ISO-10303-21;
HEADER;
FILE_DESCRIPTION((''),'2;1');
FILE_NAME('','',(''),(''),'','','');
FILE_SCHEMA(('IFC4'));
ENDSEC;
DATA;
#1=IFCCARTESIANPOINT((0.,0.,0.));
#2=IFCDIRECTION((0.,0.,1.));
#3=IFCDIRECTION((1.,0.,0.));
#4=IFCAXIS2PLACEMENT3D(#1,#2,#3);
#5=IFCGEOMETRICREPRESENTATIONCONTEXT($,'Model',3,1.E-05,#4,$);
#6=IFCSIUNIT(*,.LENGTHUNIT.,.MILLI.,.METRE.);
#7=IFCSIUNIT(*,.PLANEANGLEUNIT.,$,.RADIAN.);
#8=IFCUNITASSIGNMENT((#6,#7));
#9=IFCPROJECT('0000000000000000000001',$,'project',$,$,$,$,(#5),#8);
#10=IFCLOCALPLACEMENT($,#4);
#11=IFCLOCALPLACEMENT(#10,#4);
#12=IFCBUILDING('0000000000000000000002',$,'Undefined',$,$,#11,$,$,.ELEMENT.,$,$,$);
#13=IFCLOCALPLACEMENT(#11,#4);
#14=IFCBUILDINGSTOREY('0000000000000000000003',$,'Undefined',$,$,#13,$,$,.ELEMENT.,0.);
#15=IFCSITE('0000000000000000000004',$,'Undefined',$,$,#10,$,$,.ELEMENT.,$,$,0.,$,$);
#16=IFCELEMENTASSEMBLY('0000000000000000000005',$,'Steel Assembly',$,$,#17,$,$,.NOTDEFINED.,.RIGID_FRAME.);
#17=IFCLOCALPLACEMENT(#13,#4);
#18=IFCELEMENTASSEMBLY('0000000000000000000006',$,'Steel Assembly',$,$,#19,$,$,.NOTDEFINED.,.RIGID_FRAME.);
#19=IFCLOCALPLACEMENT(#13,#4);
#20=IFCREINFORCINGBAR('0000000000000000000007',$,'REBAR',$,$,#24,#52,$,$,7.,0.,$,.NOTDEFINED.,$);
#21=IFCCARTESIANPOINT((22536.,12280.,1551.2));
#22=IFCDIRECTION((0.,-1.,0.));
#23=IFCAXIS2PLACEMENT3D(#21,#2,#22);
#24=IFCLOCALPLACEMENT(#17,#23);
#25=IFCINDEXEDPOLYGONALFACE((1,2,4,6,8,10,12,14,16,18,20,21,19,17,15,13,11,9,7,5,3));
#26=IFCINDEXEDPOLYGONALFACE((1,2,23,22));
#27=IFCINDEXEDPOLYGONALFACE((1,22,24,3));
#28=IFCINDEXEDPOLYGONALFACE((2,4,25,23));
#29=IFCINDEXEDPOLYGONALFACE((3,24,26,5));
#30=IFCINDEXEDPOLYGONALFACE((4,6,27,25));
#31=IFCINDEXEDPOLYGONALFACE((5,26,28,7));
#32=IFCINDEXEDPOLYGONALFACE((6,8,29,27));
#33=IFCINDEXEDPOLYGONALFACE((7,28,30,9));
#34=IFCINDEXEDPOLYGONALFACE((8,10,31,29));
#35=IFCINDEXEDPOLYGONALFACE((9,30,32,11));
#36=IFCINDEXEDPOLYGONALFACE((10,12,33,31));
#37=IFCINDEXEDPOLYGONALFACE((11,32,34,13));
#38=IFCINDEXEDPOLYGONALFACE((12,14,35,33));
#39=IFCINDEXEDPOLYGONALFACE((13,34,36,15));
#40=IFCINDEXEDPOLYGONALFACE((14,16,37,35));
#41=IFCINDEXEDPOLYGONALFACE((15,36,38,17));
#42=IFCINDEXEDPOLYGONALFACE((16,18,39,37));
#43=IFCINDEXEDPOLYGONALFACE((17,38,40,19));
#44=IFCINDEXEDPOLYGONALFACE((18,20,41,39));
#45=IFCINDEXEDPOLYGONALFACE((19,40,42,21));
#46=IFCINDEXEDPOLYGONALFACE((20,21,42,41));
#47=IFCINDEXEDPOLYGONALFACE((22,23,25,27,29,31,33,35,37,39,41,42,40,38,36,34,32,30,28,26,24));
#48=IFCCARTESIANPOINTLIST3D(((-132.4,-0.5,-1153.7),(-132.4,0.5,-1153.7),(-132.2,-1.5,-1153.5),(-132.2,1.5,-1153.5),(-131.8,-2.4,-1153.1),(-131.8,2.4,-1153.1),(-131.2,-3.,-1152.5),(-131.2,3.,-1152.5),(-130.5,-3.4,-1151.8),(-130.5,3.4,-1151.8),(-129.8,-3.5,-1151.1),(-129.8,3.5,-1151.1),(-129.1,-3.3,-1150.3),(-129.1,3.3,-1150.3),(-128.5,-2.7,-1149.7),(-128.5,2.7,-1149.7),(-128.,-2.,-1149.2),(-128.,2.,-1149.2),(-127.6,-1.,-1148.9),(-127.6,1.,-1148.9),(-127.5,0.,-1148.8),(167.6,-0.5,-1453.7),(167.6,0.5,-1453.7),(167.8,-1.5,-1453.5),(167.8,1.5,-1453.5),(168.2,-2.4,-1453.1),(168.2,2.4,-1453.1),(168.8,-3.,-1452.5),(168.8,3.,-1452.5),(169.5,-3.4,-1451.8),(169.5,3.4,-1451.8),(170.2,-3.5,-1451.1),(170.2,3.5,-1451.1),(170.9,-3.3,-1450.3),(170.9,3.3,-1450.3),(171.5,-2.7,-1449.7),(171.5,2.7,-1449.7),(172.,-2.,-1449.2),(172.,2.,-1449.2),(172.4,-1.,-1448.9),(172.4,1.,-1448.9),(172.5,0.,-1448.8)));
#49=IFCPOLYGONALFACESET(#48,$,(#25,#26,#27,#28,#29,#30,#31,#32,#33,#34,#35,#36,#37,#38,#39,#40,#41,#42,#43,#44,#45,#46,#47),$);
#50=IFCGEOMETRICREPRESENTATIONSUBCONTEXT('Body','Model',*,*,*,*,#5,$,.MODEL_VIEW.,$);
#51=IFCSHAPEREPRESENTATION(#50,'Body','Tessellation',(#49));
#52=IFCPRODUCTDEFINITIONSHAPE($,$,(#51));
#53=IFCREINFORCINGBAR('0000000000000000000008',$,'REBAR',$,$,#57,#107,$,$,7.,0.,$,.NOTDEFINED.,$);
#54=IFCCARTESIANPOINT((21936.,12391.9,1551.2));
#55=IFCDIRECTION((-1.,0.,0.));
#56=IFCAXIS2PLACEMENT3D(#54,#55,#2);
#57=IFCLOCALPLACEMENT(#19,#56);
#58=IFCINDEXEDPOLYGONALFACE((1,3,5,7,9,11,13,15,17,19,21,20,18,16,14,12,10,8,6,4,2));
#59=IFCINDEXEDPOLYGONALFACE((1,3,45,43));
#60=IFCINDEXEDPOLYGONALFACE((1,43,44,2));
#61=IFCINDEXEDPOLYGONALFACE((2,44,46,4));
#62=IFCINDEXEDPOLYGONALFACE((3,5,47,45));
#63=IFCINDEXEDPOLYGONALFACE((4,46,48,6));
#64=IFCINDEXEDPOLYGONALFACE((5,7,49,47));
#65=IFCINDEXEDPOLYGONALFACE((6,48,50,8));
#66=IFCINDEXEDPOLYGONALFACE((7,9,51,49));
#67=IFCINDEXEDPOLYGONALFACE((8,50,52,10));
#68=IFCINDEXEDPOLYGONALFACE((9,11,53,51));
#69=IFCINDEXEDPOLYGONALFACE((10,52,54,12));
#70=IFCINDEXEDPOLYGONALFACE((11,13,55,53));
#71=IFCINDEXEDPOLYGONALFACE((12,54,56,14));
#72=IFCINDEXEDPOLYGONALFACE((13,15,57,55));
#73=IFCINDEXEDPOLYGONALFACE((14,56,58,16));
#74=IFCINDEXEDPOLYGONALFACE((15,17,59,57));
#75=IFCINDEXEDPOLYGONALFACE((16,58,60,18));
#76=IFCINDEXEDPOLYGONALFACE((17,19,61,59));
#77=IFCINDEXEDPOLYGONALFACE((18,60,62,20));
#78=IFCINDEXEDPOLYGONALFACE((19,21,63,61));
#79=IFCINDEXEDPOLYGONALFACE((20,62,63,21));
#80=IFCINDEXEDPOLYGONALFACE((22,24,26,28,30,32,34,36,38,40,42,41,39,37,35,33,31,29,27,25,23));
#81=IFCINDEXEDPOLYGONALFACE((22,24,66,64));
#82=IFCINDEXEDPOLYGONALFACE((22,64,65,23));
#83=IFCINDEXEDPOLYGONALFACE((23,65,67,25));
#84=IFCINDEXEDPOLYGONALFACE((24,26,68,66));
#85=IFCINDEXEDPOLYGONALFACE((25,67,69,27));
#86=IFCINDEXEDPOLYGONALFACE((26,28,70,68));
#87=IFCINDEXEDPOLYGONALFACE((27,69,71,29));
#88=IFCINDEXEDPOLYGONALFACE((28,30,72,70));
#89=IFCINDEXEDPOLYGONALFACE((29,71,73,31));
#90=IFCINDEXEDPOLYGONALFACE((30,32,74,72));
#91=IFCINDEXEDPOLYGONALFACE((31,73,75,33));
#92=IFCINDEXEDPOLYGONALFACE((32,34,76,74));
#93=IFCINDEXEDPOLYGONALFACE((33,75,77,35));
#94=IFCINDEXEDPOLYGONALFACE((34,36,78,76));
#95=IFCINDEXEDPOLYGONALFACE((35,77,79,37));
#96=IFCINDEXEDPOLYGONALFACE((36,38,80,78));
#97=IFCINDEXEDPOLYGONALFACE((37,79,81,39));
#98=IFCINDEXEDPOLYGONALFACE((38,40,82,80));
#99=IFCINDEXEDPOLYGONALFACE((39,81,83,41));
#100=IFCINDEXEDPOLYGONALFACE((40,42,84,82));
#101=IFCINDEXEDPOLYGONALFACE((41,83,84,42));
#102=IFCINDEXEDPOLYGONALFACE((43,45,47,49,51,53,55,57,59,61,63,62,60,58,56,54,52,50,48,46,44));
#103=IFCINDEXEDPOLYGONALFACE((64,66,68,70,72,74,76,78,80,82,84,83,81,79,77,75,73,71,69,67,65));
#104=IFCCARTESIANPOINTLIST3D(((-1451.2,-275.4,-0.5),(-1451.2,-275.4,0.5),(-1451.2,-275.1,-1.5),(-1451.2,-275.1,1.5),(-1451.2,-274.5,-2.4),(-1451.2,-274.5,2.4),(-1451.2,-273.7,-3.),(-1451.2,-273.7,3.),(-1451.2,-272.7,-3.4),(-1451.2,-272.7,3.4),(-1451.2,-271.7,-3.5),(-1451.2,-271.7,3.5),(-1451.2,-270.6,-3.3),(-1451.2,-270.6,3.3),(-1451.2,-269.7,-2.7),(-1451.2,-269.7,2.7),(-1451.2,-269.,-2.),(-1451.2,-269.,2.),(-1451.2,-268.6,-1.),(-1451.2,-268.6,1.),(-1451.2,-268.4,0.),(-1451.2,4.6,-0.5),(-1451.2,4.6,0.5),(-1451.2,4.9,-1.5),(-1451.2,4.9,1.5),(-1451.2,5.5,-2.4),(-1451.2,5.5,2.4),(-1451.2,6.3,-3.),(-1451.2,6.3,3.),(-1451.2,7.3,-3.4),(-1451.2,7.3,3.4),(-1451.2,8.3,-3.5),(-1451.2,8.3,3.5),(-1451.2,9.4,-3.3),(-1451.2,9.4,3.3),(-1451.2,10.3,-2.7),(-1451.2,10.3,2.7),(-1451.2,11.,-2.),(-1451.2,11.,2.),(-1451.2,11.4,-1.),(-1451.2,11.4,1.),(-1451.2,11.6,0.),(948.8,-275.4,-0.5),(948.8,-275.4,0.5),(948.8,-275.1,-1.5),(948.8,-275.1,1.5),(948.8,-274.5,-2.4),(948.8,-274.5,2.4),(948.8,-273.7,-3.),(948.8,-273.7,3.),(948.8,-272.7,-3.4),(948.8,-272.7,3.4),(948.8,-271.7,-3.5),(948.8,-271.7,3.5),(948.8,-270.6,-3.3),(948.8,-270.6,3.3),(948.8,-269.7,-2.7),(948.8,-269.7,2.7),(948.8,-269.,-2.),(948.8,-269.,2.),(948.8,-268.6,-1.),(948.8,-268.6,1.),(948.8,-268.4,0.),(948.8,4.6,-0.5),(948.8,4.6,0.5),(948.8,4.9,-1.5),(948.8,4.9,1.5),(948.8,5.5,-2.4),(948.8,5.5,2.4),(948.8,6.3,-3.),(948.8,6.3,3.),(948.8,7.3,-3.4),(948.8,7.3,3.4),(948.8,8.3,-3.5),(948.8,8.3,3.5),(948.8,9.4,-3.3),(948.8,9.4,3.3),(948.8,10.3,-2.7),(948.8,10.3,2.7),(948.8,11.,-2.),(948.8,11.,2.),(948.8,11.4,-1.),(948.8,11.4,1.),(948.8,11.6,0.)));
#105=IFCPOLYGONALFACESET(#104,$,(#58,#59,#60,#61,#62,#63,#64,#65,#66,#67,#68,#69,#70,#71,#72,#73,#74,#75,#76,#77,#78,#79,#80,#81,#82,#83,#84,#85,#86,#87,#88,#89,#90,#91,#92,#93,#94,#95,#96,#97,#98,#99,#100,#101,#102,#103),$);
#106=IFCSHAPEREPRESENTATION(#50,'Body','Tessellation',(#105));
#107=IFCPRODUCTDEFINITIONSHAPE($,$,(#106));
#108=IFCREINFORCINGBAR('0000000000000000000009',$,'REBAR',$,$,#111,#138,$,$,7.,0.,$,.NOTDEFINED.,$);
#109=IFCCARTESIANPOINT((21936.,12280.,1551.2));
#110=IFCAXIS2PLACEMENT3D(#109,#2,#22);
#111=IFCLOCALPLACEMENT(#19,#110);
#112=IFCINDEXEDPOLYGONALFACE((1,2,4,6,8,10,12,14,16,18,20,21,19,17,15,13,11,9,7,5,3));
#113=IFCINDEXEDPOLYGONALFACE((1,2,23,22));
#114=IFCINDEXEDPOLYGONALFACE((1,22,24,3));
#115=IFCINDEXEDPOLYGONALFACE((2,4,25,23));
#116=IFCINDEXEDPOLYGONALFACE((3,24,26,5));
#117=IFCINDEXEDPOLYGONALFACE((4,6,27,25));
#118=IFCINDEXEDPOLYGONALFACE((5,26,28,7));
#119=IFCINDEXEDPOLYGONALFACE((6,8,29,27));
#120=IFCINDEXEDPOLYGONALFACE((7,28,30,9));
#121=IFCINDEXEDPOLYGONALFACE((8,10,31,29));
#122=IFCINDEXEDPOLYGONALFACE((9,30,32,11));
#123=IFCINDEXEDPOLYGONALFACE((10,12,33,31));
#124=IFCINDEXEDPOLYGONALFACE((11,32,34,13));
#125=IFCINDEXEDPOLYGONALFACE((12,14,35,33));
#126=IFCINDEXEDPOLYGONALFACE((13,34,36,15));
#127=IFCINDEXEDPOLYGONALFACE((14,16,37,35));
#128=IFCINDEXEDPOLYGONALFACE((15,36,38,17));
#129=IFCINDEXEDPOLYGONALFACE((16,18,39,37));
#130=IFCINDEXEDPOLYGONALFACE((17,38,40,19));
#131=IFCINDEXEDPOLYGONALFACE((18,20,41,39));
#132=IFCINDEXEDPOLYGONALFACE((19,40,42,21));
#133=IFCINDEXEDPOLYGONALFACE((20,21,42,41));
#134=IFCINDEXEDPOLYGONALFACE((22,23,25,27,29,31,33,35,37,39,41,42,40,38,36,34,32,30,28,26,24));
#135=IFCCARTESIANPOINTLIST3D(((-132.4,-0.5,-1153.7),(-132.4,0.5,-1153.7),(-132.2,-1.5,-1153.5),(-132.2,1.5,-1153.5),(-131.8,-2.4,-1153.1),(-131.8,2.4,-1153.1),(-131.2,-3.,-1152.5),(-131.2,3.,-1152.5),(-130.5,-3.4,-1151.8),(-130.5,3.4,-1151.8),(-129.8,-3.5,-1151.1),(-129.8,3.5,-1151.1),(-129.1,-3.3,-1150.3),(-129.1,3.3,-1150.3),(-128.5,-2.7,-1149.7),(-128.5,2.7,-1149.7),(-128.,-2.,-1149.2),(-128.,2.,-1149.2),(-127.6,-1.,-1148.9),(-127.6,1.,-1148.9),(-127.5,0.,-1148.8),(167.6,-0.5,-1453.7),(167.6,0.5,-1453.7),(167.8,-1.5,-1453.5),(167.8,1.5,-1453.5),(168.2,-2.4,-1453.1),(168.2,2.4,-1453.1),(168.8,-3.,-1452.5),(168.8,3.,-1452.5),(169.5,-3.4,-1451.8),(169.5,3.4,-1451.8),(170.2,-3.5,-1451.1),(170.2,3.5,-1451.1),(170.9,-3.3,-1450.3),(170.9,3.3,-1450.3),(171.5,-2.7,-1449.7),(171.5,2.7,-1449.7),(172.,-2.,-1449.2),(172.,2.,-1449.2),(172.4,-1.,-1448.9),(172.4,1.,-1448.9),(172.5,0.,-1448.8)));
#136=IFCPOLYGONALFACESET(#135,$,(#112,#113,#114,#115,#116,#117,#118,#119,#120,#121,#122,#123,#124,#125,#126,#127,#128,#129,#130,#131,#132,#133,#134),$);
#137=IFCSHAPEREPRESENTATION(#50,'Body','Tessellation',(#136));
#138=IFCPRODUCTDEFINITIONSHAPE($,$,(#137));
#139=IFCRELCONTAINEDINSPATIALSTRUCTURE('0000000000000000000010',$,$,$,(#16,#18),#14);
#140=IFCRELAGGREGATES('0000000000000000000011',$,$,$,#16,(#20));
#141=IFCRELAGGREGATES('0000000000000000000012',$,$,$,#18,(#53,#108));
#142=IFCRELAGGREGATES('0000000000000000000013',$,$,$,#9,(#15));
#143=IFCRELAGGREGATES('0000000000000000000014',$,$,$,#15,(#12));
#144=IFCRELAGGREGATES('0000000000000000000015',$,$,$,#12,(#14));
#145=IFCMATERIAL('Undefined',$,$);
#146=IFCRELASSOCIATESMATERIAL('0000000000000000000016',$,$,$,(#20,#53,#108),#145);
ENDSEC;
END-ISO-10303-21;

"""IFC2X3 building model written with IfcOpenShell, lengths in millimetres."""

from ifc_helpers import new_model, entity, si_unit, frame, origin_with_axes, place, context, subcontext, project, spatial, source, transform, mapped, material, element, aggregate, save


model = new_model("IFC2X3")

# Units and contexts
model_context = context("Model", 3, precision=1e-05, world=origin_with_axes())
body_context = subcontext(model_context, "Body", "Model", "MODEL_VIEW")
ifc_project = project(units=[si_unit("LENGTHUNIT", "METRE", prefix="MILLI"), si_unit("PLANEANGLEUNIT", "RADIAN")], contexts=[model_context])

# Site, building, storey
site_placement = place(None, origin_with_axes())
site = spatial("IfcSite", under=ifc_project, at=site_placement, Name="Undefined", CompositionType="ELEMENT", RefElevation=0.0)
building_placement = place(site_placement, origin_with_axes())
building = spatial("IfcBuilding", under=site, at=building_placement, Name="Undefined", CompositionType="ELEMENT")
storey_placement = place(building_placement, origin_with_axes())
storey = spatial("IfcBuildingStorey", under=building, at=storey_placement, Name="Undefined", CompositionType="ELEMENT", Elevation=0.0)

# Element assemblies
assembly_1_placement = place(storey_placement, origin_with_axes())
assembly_1 = element("IfcElementAssembly", 1, at=assembly_1_placement, inside=storey, Name="Steel Assembly", AssemblyPlace="NOTDEFINED", PredefinedType="RIGID_FRAME")
assembly_2_placement = place(storey_placement, origin_with_axes())
assembly_2 = element("IfcElementAssembly", 2, at=assembly_2_placement, inside=storey, Name="Steel Assembly", AssemblyPlace="NOTDEFINED", PredefinedType="RIGID_FRAME")

# Shared definitions
ifc_material_1 = material(Name="Undefined")

# Reinforcing bars
shared_shape_1 = source(origin_with_axes(), body_context, "Body", "AdvancedSweptSolid", [
    entity("IfcSweptDiskSolid", entity("IfcTrimmedCurve", entity("IfcLine", entity("IfcCartesianPoint", [0.0, 0.0, 0.0]), entity("IfcVector", entity("IfcDirection", [0.707107, 0.0, -0.707107]), 1.0)), [entity("IfcParameterValue", 0.0)], [entity("IfcParameterValue", 424.264069)], True, "PARAMETER"), 3.5, None, 0.0, 424.3),
])
reinforcing_bar_1_placement = place(assembly_1_placement, frame((22536.0, 12280.0, 1551.2), z_axis=(0.0, 0.0, 1.0), x_axis=(0.0, -1.0, 0.0)))
reinforcing_bar_1 = element("IfcReinforcingBar", 3, at=reinforcing_bar_1_placement, material=ifc_material_1, Name="REBAR", BarRole="NOTDEFINED", CrossSectionArea=0.0, NominalDiameter=7.0, context=body_context, shape_type="MappedRepresentation", body=[
    mapped(shared_shape_1, transform((-130.0, 0.0, -1151.2))),
])
aggregate(assembly_1, [reinforcing_bar_1])
shared_shape_2 = source(origin_with_axes(), body_context, "Body", "AdvancedSweptSolid", [
    entity("IfcSweptDiskSolid", entity("IfcTrimmedCurve", entity("IfcLine", entity("IfcCartesianPoint", [0.0, 0.0, 0.0]), entity("IfcVector", entity("IfcDirection", [1.0, 0.000003, 0.0]), 1.0)), [entity("IfcParameterValue", 0.0)], [entity("IfcParameterValue", 2400.0)], True, "PARAMETER"), 3.5, None, 0.0, 2400.0),
])
shared_shape_3 = source(origin_with_axes(), body_context, "Body", "AdvancedSweptSolid", [
    entity("IfcSweptDiskSolid", entity("IfcTrimmedCurve", entity("IfcLine", entity("IfcCartesianPoint", [0.0, 0.0, 0.0]), entity("IfcVector", entity("IfcDirection", [1.0, 0.000003, 0.0]), 1.0)), [entity("IfcParameterValue", 0.0)], [entity("IfcParameterValue", 2400.0)], True, "PARAMETER"), 3.5, None, 0.0, 2400.0),
])
reinforcing_bar_2_placement = place(assembly_2_placement, frame((21936.0, 12391.9, 1551.2), z_axis=(-1.0, 0.0, 0.0), x_axis=(0.0, 0.0, 1.0)))
reinforcing_bar_2 = element("IfcReinforcingBar", 4, at=reinforcing_bar_2_placement, material=ifc_material_1, Name="REBAR", BarRole="NOTDEFINED", CrossSectionArea=0.0, NominalDiameter=7.0, context=body_context, shape_type="MappedRepresentation", body=[
    mapped(shared_shape_2, transform((-1451.2, -271.9, 0.0))),
    mapped(shared_shape_3, transform((-1451.2, 8.1, 0.0))),
])
shared_shape_4 = source(origin_with_axes(), body_context, "Body", "AdvancedSweptSolid", [
    entity("IfcSweptDiskSolid", entity("IfcTrimmedCurve", entity("IfcLine", entity("IfcCartesianPoint", [0.0, 0.0, 0.0]), entity("IfcVector", entity("IfcDirection", [0.707107, 0.0, -0.707107]), 1.0)), [entity("IfcParameterValue", 0.0)], [entity("IfcParameterValue", 424.264069)], True, "PARAMETER"), 3.5, None, 0.0, 424.3),
])
reinforcing_bar_3_placement = place(assembly_2_placement, frame((21936.0, 12280.0, 1551.2), z_axis=(0.0, 0.0, 1.0), x_axis=(0.0, -1.0, 0.0)))
reinforcing_bar_3 = element("IfcReinforcingBar", 5, at=reinforcing_bar_3_placement, material=ifc_material_1, Name="REBAR", BarRole="NOTDEFINED", CrossSectionArea=0.0, NominalDiameter=7.0, context=body_context, shape_type="MappedRepresentation", body=[
    mapped(shared_shape_4, transform((-130.0, 0.0, -1151.2))),
])
aggregate(assembly_2, [reinforcing_bar_2, reinforcing_bar_3])

save(model, "model.ifc")
